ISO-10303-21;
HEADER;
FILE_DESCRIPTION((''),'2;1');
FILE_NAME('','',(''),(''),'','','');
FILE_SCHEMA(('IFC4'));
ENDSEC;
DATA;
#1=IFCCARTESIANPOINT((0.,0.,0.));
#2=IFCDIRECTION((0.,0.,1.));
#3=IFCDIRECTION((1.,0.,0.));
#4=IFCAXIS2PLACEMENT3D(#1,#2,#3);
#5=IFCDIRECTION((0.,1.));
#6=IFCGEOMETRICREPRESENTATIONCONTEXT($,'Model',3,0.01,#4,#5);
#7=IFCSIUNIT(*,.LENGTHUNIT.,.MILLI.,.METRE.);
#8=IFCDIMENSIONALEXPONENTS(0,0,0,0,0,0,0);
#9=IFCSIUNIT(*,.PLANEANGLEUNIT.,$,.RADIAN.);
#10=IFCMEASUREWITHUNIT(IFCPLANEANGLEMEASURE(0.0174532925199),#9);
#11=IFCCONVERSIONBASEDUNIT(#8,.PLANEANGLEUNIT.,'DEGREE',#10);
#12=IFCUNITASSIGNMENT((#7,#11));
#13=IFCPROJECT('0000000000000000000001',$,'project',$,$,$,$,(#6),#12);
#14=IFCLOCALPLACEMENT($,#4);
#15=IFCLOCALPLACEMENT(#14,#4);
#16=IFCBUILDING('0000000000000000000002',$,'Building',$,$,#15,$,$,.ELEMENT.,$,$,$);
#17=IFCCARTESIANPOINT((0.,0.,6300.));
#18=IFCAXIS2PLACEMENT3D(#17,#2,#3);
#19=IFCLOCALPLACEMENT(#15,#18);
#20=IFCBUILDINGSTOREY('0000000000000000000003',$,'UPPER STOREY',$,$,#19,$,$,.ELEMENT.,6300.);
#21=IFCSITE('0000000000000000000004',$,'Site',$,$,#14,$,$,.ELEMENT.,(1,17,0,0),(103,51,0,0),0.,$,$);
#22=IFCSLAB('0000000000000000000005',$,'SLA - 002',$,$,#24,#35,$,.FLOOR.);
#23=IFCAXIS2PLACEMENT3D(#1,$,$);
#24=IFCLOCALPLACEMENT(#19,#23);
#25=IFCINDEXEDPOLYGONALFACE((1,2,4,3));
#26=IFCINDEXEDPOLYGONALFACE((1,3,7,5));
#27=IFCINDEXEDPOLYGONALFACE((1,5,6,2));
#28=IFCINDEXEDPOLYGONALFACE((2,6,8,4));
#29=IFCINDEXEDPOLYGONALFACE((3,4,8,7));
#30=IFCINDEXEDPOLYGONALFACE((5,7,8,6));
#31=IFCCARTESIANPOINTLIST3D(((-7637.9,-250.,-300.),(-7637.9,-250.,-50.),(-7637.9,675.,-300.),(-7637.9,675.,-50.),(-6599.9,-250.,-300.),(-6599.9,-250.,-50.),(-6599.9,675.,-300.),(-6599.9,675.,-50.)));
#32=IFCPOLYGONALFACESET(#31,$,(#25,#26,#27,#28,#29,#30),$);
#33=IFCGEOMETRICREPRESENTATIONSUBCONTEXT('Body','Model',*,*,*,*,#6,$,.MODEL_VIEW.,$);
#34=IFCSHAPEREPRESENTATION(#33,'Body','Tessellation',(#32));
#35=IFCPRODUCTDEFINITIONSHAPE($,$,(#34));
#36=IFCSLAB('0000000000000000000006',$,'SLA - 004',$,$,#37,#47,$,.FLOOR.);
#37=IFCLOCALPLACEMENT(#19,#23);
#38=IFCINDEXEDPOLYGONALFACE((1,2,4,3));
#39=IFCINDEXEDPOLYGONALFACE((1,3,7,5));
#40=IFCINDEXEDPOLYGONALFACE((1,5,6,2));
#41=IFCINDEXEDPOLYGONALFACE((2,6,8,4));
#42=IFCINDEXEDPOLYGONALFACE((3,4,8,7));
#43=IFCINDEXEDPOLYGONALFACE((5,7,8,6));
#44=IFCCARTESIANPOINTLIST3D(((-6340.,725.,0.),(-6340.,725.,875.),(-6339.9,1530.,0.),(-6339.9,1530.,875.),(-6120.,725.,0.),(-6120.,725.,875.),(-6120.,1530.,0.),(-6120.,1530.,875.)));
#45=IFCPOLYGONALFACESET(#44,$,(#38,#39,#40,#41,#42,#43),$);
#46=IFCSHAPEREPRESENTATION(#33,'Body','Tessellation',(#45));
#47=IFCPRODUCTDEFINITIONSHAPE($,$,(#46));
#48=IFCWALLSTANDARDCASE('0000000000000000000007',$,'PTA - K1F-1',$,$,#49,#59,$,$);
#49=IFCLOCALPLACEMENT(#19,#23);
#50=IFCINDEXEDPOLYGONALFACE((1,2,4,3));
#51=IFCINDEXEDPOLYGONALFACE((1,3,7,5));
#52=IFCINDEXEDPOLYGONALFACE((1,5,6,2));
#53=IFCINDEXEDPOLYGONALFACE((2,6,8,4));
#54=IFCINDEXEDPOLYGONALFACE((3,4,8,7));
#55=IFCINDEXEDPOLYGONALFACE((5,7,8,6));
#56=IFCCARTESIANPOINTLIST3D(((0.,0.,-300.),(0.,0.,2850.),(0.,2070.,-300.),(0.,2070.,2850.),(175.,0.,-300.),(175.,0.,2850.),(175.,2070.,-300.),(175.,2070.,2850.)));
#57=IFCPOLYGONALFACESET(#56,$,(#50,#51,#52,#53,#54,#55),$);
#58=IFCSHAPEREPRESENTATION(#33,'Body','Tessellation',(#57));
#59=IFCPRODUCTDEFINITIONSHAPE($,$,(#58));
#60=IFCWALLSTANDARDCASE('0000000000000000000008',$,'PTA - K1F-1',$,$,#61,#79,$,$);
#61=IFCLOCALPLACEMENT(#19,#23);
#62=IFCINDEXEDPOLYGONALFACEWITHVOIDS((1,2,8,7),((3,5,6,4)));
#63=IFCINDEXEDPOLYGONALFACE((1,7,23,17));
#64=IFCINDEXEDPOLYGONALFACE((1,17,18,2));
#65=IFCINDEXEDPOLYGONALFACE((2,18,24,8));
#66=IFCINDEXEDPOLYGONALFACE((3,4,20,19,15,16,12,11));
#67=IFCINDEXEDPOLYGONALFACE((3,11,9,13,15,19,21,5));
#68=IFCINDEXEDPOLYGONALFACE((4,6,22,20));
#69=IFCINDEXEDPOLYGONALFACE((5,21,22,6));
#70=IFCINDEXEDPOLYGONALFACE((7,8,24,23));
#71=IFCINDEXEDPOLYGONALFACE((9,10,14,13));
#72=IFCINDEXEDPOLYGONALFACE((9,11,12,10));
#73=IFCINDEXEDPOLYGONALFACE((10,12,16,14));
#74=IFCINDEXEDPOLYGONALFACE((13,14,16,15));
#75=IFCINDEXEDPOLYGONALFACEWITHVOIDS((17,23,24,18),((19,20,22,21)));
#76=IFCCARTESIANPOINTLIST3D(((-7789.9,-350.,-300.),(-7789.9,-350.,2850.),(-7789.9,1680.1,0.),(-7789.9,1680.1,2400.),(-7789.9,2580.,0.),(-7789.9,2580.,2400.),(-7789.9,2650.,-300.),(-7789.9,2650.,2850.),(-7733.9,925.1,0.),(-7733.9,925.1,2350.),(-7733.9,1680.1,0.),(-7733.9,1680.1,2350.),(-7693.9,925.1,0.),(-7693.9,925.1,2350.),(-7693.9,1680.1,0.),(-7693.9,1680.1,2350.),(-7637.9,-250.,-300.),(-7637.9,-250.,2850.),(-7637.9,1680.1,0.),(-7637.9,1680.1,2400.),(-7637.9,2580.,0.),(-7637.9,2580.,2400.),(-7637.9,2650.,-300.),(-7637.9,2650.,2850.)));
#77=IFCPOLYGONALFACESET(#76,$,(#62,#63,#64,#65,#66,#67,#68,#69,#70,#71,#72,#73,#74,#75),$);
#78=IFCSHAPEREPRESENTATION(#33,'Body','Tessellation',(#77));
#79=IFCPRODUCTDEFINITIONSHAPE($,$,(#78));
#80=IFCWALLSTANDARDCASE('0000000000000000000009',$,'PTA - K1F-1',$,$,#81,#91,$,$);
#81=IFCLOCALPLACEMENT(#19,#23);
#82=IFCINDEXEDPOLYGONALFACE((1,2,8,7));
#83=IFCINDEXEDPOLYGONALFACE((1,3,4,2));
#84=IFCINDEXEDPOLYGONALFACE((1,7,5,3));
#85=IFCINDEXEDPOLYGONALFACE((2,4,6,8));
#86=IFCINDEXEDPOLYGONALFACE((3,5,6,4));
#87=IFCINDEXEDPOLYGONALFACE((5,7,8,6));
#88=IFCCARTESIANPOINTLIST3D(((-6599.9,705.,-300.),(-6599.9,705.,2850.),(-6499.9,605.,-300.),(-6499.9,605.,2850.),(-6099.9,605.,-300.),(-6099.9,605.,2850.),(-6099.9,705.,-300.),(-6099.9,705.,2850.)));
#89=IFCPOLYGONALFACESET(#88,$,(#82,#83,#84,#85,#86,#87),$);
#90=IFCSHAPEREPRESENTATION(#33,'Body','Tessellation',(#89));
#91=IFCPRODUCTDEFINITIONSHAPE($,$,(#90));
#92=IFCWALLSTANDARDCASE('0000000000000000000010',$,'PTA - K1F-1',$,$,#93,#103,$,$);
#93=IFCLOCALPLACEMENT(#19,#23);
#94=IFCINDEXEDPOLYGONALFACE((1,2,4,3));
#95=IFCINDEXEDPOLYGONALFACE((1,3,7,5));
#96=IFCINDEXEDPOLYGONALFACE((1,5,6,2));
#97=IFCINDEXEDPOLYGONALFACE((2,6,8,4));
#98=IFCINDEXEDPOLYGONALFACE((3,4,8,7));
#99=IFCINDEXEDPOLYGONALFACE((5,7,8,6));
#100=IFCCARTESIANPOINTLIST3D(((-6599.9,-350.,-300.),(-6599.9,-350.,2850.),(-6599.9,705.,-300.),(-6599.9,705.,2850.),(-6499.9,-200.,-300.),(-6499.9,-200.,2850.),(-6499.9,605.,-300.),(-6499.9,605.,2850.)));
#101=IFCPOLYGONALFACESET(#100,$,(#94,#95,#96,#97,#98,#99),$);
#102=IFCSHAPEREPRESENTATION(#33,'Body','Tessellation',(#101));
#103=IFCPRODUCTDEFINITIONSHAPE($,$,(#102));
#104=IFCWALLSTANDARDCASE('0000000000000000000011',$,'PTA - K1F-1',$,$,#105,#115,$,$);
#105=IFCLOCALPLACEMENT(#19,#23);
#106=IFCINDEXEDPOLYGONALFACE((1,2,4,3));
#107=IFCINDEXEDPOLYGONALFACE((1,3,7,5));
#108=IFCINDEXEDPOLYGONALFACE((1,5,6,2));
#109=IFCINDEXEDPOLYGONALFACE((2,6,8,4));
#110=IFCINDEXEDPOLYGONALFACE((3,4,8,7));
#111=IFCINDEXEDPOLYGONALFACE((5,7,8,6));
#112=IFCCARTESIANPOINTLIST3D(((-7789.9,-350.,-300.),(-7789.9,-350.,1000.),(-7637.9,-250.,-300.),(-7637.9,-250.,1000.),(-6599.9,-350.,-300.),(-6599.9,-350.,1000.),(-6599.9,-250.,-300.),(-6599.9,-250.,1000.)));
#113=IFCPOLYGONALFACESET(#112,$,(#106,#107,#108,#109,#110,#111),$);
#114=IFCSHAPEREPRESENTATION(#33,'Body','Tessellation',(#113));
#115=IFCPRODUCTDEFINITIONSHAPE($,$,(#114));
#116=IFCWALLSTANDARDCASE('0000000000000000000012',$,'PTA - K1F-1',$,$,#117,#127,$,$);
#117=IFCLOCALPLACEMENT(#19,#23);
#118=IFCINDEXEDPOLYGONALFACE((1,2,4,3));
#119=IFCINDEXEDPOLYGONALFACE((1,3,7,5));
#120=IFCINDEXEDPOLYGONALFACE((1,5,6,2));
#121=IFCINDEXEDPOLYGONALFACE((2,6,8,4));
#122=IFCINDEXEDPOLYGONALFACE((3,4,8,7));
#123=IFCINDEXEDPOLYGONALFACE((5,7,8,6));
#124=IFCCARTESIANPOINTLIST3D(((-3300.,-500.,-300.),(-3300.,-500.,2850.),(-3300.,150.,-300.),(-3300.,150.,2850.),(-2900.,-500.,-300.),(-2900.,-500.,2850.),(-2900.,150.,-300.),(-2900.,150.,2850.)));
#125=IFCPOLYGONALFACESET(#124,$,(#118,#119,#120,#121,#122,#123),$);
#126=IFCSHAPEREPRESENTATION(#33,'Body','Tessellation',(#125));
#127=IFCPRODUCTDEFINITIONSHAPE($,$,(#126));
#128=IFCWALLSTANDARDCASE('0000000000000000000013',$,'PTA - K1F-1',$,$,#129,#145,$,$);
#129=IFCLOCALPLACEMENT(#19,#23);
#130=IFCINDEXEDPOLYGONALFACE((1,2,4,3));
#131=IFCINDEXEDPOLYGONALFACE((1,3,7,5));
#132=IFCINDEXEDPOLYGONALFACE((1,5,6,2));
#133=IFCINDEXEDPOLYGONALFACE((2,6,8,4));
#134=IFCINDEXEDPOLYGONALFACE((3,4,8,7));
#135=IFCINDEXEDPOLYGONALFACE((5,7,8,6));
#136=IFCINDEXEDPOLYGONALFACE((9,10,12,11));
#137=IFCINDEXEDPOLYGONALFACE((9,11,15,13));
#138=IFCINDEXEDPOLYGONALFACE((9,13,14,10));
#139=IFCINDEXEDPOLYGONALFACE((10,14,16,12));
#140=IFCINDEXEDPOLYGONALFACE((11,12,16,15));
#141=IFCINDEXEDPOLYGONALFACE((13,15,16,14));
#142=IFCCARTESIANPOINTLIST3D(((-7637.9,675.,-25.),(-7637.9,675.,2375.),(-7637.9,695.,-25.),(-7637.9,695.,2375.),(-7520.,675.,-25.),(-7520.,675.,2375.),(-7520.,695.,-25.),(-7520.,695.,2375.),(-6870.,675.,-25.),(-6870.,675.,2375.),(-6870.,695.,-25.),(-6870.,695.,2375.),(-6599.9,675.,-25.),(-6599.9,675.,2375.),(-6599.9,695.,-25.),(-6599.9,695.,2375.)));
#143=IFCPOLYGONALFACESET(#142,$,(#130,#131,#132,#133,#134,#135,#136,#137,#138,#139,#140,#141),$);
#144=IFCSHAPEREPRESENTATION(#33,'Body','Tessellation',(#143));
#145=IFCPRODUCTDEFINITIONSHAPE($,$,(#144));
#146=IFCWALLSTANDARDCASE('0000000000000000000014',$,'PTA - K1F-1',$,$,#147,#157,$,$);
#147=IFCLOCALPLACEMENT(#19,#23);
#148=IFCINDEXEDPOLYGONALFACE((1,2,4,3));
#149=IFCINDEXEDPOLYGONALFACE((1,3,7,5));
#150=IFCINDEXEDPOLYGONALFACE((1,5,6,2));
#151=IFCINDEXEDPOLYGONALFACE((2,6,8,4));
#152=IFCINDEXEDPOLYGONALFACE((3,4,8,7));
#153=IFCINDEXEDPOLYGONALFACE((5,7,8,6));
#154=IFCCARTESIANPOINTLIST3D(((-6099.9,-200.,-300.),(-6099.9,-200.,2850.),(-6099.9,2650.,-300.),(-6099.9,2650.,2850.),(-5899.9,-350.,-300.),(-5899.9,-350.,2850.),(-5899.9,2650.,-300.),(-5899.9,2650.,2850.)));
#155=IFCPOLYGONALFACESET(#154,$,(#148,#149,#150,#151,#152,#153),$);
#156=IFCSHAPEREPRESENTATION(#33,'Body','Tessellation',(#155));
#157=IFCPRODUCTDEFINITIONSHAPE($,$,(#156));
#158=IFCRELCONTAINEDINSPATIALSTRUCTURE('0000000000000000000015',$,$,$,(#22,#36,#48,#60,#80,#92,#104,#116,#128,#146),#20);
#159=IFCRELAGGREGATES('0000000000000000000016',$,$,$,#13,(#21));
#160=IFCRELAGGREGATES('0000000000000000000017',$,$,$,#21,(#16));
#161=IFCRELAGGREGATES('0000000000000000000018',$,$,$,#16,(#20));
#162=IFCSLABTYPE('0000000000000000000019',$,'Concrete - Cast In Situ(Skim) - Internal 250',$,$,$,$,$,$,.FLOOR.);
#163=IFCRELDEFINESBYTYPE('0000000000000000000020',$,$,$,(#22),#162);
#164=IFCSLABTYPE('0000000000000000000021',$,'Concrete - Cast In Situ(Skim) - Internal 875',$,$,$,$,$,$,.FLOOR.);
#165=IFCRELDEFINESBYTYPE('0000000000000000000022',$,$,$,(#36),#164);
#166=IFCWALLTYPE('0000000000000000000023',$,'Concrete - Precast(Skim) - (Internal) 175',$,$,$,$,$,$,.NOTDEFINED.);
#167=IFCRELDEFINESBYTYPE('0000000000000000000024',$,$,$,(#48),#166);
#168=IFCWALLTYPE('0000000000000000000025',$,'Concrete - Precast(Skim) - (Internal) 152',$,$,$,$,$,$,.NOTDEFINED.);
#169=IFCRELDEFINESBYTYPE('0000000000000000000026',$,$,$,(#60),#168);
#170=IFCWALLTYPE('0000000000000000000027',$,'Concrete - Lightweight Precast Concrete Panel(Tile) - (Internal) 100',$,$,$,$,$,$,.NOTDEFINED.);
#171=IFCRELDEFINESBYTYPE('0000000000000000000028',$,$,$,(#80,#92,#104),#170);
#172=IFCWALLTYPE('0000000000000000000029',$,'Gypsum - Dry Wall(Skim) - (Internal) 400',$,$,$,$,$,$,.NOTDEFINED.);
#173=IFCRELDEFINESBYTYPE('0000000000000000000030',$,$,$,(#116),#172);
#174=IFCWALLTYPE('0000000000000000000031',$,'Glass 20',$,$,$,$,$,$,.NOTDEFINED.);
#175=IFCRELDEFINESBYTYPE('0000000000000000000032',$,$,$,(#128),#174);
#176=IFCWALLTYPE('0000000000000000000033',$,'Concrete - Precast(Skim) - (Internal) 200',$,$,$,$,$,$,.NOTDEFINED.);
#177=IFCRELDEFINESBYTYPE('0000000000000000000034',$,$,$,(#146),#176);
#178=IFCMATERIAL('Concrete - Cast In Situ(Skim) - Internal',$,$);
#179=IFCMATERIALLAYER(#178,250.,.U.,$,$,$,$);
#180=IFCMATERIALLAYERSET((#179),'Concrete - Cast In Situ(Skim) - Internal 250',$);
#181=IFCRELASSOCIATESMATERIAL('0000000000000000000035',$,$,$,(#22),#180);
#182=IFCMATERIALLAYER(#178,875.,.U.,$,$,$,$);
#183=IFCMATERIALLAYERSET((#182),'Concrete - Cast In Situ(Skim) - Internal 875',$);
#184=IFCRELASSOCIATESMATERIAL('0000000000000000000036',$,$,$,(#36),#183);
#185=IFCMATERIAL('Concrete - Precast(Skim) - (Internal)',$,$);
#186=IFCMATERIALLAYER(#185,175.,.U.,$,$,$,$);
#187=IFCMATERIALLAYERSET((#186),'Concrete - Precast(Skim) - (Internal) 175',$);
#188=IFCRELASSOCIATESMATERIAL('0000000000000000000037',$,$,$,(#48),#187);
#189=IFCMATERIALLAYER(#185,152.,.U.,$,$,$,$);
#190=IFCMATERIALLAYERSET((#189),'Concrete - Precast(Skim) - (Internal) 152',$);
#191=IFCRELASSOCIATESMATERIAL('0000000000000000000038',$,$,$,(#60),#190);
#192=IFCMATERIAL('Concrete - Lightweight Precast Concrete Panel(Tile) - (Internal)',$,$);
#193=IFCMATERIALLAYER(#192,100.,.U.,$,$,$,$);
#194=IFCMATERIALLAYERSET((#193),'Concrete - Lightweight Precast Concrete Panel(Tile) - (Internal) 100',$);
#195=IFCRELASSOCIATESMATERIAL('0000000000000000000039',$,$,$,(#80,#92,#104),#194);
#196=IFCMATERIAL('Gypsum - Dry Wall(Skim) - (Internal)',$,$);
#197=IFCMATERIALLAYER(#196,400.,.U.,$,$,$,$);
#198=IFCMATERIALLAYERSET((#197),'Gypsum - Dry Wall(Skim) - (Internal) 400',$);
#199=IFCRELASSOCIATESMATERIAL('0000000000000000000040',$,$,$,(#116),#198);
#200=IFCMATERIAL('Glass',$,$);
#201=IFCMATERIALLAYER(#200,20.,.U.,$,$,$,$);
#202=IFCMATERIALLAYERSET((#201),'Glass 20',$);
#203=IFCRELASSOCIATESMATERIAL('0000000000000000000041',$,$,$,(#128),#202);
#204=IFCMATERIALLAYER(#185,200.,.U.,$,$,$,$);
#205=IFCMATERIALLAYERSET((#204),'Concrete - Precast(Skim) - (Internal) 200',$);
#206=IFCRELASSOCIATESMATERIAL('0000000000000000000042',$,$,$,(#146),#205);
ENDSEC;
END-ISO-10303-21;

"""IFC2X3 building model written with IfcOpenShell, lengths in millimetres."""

from ifc_helpers import new_model, entity, si_unit, converted_unit, direction, frame, origin_with_axes, origin_2d_with_axis, place, context, subcontext, project, spatial, polyline, rectangle, outline, extrude, material, layer, layer_set, layer_usage, type_object, element, save


model = new_model("IFC2X3")

# Units and contexts
model_context = context("Model", 3, precision=0.01, world=origin_with_axes(), true_north=direction((0.0, 1.0)))
body_context = subcontext(model_context, "Body", "Model", "MODEL_VIEW")
ifc_project = project(units=[si_unit("LENGTHUNIT", "METRE", prefix="MILLI"), converted_unit("PLANEANGLEUNIT", "DEGREE", entity("IfcPlaneAngleMeasure", 0.0174532925199), si_unit("PLANEANGLEUNIT", "RADIAN"), dimensions=[0, 0, 0, 0, 0, 0, 0])], contexts=[model_context])

# Site, building, storey
site_placement = place(None, origin_with_axes())
site = spatial("IfcSite", under=ifc_project, at=site_placement, Name="Site", CompositionType="ELEMENT", RefLatitude=(1, 17, 0, 0), RefLongitude=(103, 51, 0, 0), RefElevation=0.0)
building_placement = place(site_placement, origin_with_axes())
building = spatial("IfcBuilding", under=site, at=building_placement, Name="Building", CompositionType="ELEMENT")
storey_placement = place(building_placement, frame((0.0, 0.0, 6300.0), z_axis=(0.0, 0.0, 1.0), x_axis=(1.0, 0.0, 0.0)))
storey = spatial("IfcBuildingStorey", under=building, at=storey_placement, Name="UPPER STOREY", CompositionType="ELEMENT", Elevation=6300.0)

# Slabs
ifc_material_1 = material(Name="Concrete - Cast In Situ(Skim) - Internal")
ifc_layer_1 = layer(ifc_material_1, 250.0, ventilated="UNKNOWN")
ifc_layer_set_1 = layer_set([ifc_layer_1], Name="Concrete - Cast In Situ(Skim) - Internal 250")
ifc_layer_usage_1 = layer_usage(ifc_layer_set_1, "AXIS3", "NEGATIVE", 250.0)
slab_type_1 = type_object("IfcSlabType", Name="Concrete - Cast In Situ(Skim) - Internal 250", PredefinedType="FLOOR")
slab_1_placement = place(storey_placement, frame((-6599.9, 675.0, -50.0), z_axis=(0.0, 0.0, 1.0), x_axis=(1.0, 0.0, 0.0)))
element("IfcSlab", 1, at=slab_1_placement, inside=storey, type_object=slab_type_1, material=ifc_layer_usage_1, Name="SLA - 002", PredefinedType="FLOOR", context=body_context, shape_type="SweptSolid", body=[
    extrude(outline(polyline([(0.0, 0.0), (-1038.0, 0.0), (-1038.0, -925.0), (0.0, -925.0), (0.0, 0.0)])), frame((0.0, 0.0, -250.0), z_axis=(0.0, 0.0, 1.0), x_axis=(1.0, 0.0, 0.0)), (0.0, 0.0, 1.0), 250.0),
])
ifc_layer_2 = layer(ifc_material_1, 875.0, ventilated="UNKNOWN")
ifc_layer_set_2 = layer_set([ifc_layer_2], Name="Concrete - Cast In Situ(Skim) - Internal 875")
ifc_layer_usage_2 = layer_usage(ifc_layer_set_2, "AXIS3", "NEGATIVE", 875.0)
slab_type_2 = type_object("IfcSlabType", Name="Concrete - Cast In Situ(Skim) - Internal 875", PredefinedType="FLOOR")
slab_2_placement = place(storey_placement, frame((-6120.0, 725.0, 875.0), z_axis=(0.0, 0.0, 1.0), x_axis=(1.0, 0.0, 0.0)))
element("IfcSlab", 2, at=slab_2_placement, inside=storey, type_object=slab_type_2, material=ifc_layer_usage_2, Name="SLA - 004", PredefinedType="FLOOR", context=body_context, shape_type="SweptSolid", body=[
    extrude(outline(polyline([(0.0, 0.0), (0.0, 805.0), (-219.9, 805.1), (-220.0, 0.0), (0.0, 0.0)])), frame((0.0, 0.0, -875.0), z_axis=(0.0, 0.0, 1.0), x_axis=(1.0, 0.0, 0.0)), (0.0, 0.0, 1.0), 875.0),
])

# Wall
ifc_material_2 = material(Name="Concrete - Precast(Skim) - (Internal)")
ifc_layer_3 = layer(ifc_material_2, 175.0, ventilated="UNKNOWN")
ifc_layer_set_3 = layer_set([ifc_layer_3], Name="Concrete - Precast(Skim) - (Internal) 175")
ifc_layer_usage_3 = layer_usage(ifc_layer_set_3, "AXIS2", "NEGATIVE", 0.0)
wall_type_1 = type_object("IfcWallType", Name="Concrete - Precast(Skim) - (Internal) 175", PredefinedType="NOTDEFINED")
wall_1_placement = place(storey_placement, frame((0.0, 0.0, -300.0), z_axis=(0.0, 0.0, 1.0), x_axis=(-0.000002, 1.0, 0.0)))
element("IfcWallStandardCase", 3, at=wall_1_placement, inside=storey, type_object=wall_type_1, material=ifc_layer_usage_3, Name="PTA - K1F-1", context=body_context, shape_type="SweptSolid", body=[
    extrude(outline(polyline([(0.0, -175.0), (2070.0, -175.0), (2070.0, 0.0), (0.0, 0.0), (0.0, -175.0)])), origin_with_axes(), (0.0, 0.0, 1.0), 3150.0),
])

# Wall, opening
ifc_layer_4 = layer(ifc_material_2, 152.0, ventilated="UNKNOWN")
ifc_layer_set_4 = layer_set([ifc_layer_4], Name="Concrete - Precast(Skim) - (Internal) 152")
ifc_layer_usage_4 = layer_usage(ifc_layer_set_4, "AXIS2", "NEGATIVE", 0.0)
wall_type_2 = type_object("IfcWallType", Name="Concrete - Precast(Skim) - (Internal) 152", PredefinedType="NOTDEFINED")
wall_2_placement = place(storey_placement, frame((-7789.9, -350.0, -300.0), z_axis=(0.0, 0.0, 1.0), x_axis=(0.0, 1.0, 0.0)))
wall_2 = element("IfcWallStandardCase", 4, at=wall_2_placement, inside=storey, type_object=wall_type_2, material=ifc_layer_usage_4, Name="PTA - K1F-1", context=body_context, shape_type="SweptSolid", body=[
    extrude(outline(polyline([(100.0, -152.0), (3000.0, -152.0), (3000.0, 0.0), (0.0, 0.0), (100.0, -152.0)])), origin_with_axes(), (0.0, 0.0, 1.0), 3150.0),
])
opening_1_placement = place(wall_2_placement, frame((2480.0, 0.0, 300.0), z_axis=(0.0, 0.0, 1.0), x_axis=(1.0, 0.0, 0.0)))
element("IfcOpeningElement", 5, at=opening_1_placement, cuts=wall_2, context=body_context, shape_type="SweptSolid", body=[
    extrude(rectangle(XDim=899.9, YDim=2400.0, at=origin_2d_with_axis()), frame((0.0, -152.0, 1200.0), z_axis=(0.0, -1.0, 0.0), x_axis=(-1.0, 0.0, 0.0)), (0.0, 0.0, -1.0), 456.0),
    extrude(outline(polyline([(1204.9, 0.0), (1204.9, 2350.0), (450.0, 2350.0), (450.0, 0.0), (1204.9, 0.0)])), frame((0.0, -56.0, 0.0), z_axis=(0.0, 1.0, 0.0), x_axis=(-1.0, 0.0, 0.0)), (0.0, 0.0, -1.0), 40.0),
])

# Walls
ifc_material_3 = material(Name="Concrete - Lightweight Precast Concrete Panel(Tile) - (Internal)")
ifc_layer_5 = layer(ifc_material_3, 100.0, ventilated="UNKNOWN")
ifc_layer_set_5 = layer_set([ifc_layer_5], Name="Concrete - Lightweight Precast Concrete Panel(Tile) - (Internal) 100")
ifc_layer_usage_5 = layer_usage(ifc_layer_set_5, "AXIS2", "POSITIVE", 0.0)
wall_type_3 = type_object("IfcWallType", Name="Concrete - Lightweight Precast Concrete Panel(Tile) - (Internal) 100", PredefinedType="NOTDEFINED")
wall_3_placement = place(storey_placement, frame((-6099.9, 705.0, -300.0), z_axis=(0.0, 0.0, 1.0), x_axis=(-1.0, 0.0, 0.0)))
element("IfcWallStandardCase", 6, at=wall_3_placement, inside=storey, type_object=wall_type_3, material=ifc_layer_usage_5, Name="PTA - K1F-1", context=body_context, shape_type="SweptSolid", body=[
    extrude(outline(polyline([(0.0, 0.0), (500.0, 0.0), (400.0, 100.0), (0.0, 100.0), (0.0, 0.0)])), origin_with_axes(), (0.0, 0.0, 1.0), 3150.0),
])
ifc_layer_usage_6 = layer_usage(ifc_layer_set_5, "AXIS2", "POSITIVE", 0.0)
wall_4_placement = place(storey_placement, frame((-6599.9, 705.0, -300.0), z_axis=(0.0, 0.0, 1.0), x_axis=(0.0, -1.0, 0.0)))
element("IfcWallStandardCase", 7, at=wall_4_placement, inside=storey, type_object=wall_type_3, material=ifc_layer_usage_6, Name="PTA - K1F-1", context=body_context, shape_type="SweptSolid", body=[
    extrude(outline(polyline([(0.0, 0.0), (1055.0, 0.0), (905.0, 100.0), (100.0, 100.0), (0.0, 0.0)])), origin_with_axes(), (0.0, 0.0, 1.0), 3150.0),
])
ifc_layer_usage_7 = layer_usage(ifc_layer_set_5, "AXIS2", "NEGATIVE", 0.0)
wall_5_placement = place(storey_placement, frame((-6599.9, -350.0, -300.0), z_axis=(0.0, 0.0, 1.0), x_axis=(-1.0, -0.000004, 0.0)))
element("IfcWallStandardCase", 8, at=wall_5_placement, inside=storey, type_object=wall_type_3, material=ifc_layer_usage_7, Name="PTA - K1F-1", context=body_context, shape_type="SweptSolid", body=[
    extrude(outline(polyline([(0.0, -100.0), (1038.0, -100.0), (1190.0, 0.0), (0.0, 0.0), (0.0, -100.0)])), origin_with_axes(), (0.0, 0.0, 1.0), 1300.0),
])
ifc_material_4 = material(Name="Gypsum - Dry Wall(Skim) - (Internal)")
ifc_layer_6 = layer(ifc_material_4, 400.0, ventilated="UNKNOWN")
ifc_layer_set_6 = layer_set([ifc_layer_6], Name="Gypsum - Dry Wall(Skim) - (Internal) 400")
ifc_layer_usage_8 = layer_usage(ifc_layer_set_6, "AXIS2", "POSITIVE", 0.0)
wall_type_4 = type_object("IfcWallType", Name="Gypsum - Dry Wall(Skim) - (Internal) 400", PredefinedType="NOTDEFINED")
wall_6_placement = place(storey_placement, frame((-3300.0, 150.0, -300.0), z_axis=(0.0, 0.0, 1.0), x_axis=(0.0, -1.0, 0.0)))
element("IfcWallStandardCase", 9, at=wall_6_placement, inside=storey, type_object=wall_type_4, material=ifc_layer_usage_8, Name="PTA - K1F-1", context=body_context, shape_type="SweptSolid", body=[
    extrude(outline(polyline([(0.0, 0.0), (650.0, 0.0), (650.0, 400.0), (0.0, 400.0), (0.0, 0.0)])), origin_with_axes(), (0.0, 0.0, 1.0), 3150.0),
])

# Wall, opening
ifc_material_5 = material(Name="Glass")
ifc_layer_7 = layer(ifc_material_5, 20.0, ventilated="UNKNOWN")
ifc_layer_set_7 = layer_set([ifc_layer_7], Name="Glass 20")
ifc_layer_usage_9 = layer_usage(ifc_layer_set_7, "AXIS2", "NEGATIVE", 0.0)
wall_type_5 = type_object("IfcWallType", Name="Glass 20", PredefinedType="NOTDEFINED")
wall_7_placement = place(storey_placement, frame((-7637.9, 695.0, -25.0), z_axis=(0.0, 0.0, 1.0), x_axis=(1.0, 0.0, 0.0)))
wall_7 = element("IfcWallStandardCase", 10, at=wall_7_placement, inside=storey, type_object=wall_type_5, material=ifc_layer_usage_9, Name="PTA - K1F-1", context=body_context, shape_type="SweptSolid", body=[
    extrude(outline(polyline([(0.0, -20.0), (1038.0, -20.0), (1038.0, 0.0), (0.0, 0.0), (0.0, -20.0)])), origin_with_axes(), (0.0, 0.0, 1.0), 2400.0),
])
opening_2_placement = place(wall_7_placement, frame((442.9, 0.0, 0.0), z_axis=(0.0, 0.0, 1.0), x_axis=(1.0, 0.0, 0.0)))
element("IfcOpeningElement", 11, at=opening_2_placement, cuts=wall_7, context=body_context, shape_type="SweptSolid", body=[
    extrude(rectangle(XDim=650.0, YDim=2400.0, at=origin_2d_with_axis()), frame((0.0, 20.0, 1200.0), z_axis=(0.0, 1.0, 0.0), x_axis=(-1.0, 0.0, 0.0)), (0.0, 0.0, -1.0), 60.0),
])

# Wall
ifc_layer_8 = layer(ifc_material_2, 200.0, ventilated="UNKNOWN")
ifc_layer_set_8 = layer_set([ifc_layer_8], Name="Concrete - Precast(Skim) - (Internal) 200")
ifc_layer_usage_10 = layer_usage(ifc_layer_set_8, "AXIS2", "POSITIVE", 0.0)
wall_type_6 = type_object("IfcWallType", Name="Concrete - Precast(Skim) - (Internal) 200", PredefinedType="NOTDEFINED")
wall_8_placement = place(storey_placement, frame((-5899.9, -350.0, -300.0), z_axis=(0.0, 0.0, 1.0), x_axis=(0.0, 1.0, 0.0)))
element("IfcWallStandardCase", 12, at=wall_8_placement, inside=storey, type_object=wall_type_6, material=ifc_layer_usage_10, Name="PTA - K1F-1", context=body_context, shape_type="SweptSolid", body=[
    extrude(outline(polyline([(0.0, 0.0), (3000.0, 0.0), (3000.0, 200.0), (150.0, 200.0), (0.0, 0.0)])), origin_with_axes(), (0.0, 0.0, 1.0), 3150.0),
])

save(model, "model.ifc")
